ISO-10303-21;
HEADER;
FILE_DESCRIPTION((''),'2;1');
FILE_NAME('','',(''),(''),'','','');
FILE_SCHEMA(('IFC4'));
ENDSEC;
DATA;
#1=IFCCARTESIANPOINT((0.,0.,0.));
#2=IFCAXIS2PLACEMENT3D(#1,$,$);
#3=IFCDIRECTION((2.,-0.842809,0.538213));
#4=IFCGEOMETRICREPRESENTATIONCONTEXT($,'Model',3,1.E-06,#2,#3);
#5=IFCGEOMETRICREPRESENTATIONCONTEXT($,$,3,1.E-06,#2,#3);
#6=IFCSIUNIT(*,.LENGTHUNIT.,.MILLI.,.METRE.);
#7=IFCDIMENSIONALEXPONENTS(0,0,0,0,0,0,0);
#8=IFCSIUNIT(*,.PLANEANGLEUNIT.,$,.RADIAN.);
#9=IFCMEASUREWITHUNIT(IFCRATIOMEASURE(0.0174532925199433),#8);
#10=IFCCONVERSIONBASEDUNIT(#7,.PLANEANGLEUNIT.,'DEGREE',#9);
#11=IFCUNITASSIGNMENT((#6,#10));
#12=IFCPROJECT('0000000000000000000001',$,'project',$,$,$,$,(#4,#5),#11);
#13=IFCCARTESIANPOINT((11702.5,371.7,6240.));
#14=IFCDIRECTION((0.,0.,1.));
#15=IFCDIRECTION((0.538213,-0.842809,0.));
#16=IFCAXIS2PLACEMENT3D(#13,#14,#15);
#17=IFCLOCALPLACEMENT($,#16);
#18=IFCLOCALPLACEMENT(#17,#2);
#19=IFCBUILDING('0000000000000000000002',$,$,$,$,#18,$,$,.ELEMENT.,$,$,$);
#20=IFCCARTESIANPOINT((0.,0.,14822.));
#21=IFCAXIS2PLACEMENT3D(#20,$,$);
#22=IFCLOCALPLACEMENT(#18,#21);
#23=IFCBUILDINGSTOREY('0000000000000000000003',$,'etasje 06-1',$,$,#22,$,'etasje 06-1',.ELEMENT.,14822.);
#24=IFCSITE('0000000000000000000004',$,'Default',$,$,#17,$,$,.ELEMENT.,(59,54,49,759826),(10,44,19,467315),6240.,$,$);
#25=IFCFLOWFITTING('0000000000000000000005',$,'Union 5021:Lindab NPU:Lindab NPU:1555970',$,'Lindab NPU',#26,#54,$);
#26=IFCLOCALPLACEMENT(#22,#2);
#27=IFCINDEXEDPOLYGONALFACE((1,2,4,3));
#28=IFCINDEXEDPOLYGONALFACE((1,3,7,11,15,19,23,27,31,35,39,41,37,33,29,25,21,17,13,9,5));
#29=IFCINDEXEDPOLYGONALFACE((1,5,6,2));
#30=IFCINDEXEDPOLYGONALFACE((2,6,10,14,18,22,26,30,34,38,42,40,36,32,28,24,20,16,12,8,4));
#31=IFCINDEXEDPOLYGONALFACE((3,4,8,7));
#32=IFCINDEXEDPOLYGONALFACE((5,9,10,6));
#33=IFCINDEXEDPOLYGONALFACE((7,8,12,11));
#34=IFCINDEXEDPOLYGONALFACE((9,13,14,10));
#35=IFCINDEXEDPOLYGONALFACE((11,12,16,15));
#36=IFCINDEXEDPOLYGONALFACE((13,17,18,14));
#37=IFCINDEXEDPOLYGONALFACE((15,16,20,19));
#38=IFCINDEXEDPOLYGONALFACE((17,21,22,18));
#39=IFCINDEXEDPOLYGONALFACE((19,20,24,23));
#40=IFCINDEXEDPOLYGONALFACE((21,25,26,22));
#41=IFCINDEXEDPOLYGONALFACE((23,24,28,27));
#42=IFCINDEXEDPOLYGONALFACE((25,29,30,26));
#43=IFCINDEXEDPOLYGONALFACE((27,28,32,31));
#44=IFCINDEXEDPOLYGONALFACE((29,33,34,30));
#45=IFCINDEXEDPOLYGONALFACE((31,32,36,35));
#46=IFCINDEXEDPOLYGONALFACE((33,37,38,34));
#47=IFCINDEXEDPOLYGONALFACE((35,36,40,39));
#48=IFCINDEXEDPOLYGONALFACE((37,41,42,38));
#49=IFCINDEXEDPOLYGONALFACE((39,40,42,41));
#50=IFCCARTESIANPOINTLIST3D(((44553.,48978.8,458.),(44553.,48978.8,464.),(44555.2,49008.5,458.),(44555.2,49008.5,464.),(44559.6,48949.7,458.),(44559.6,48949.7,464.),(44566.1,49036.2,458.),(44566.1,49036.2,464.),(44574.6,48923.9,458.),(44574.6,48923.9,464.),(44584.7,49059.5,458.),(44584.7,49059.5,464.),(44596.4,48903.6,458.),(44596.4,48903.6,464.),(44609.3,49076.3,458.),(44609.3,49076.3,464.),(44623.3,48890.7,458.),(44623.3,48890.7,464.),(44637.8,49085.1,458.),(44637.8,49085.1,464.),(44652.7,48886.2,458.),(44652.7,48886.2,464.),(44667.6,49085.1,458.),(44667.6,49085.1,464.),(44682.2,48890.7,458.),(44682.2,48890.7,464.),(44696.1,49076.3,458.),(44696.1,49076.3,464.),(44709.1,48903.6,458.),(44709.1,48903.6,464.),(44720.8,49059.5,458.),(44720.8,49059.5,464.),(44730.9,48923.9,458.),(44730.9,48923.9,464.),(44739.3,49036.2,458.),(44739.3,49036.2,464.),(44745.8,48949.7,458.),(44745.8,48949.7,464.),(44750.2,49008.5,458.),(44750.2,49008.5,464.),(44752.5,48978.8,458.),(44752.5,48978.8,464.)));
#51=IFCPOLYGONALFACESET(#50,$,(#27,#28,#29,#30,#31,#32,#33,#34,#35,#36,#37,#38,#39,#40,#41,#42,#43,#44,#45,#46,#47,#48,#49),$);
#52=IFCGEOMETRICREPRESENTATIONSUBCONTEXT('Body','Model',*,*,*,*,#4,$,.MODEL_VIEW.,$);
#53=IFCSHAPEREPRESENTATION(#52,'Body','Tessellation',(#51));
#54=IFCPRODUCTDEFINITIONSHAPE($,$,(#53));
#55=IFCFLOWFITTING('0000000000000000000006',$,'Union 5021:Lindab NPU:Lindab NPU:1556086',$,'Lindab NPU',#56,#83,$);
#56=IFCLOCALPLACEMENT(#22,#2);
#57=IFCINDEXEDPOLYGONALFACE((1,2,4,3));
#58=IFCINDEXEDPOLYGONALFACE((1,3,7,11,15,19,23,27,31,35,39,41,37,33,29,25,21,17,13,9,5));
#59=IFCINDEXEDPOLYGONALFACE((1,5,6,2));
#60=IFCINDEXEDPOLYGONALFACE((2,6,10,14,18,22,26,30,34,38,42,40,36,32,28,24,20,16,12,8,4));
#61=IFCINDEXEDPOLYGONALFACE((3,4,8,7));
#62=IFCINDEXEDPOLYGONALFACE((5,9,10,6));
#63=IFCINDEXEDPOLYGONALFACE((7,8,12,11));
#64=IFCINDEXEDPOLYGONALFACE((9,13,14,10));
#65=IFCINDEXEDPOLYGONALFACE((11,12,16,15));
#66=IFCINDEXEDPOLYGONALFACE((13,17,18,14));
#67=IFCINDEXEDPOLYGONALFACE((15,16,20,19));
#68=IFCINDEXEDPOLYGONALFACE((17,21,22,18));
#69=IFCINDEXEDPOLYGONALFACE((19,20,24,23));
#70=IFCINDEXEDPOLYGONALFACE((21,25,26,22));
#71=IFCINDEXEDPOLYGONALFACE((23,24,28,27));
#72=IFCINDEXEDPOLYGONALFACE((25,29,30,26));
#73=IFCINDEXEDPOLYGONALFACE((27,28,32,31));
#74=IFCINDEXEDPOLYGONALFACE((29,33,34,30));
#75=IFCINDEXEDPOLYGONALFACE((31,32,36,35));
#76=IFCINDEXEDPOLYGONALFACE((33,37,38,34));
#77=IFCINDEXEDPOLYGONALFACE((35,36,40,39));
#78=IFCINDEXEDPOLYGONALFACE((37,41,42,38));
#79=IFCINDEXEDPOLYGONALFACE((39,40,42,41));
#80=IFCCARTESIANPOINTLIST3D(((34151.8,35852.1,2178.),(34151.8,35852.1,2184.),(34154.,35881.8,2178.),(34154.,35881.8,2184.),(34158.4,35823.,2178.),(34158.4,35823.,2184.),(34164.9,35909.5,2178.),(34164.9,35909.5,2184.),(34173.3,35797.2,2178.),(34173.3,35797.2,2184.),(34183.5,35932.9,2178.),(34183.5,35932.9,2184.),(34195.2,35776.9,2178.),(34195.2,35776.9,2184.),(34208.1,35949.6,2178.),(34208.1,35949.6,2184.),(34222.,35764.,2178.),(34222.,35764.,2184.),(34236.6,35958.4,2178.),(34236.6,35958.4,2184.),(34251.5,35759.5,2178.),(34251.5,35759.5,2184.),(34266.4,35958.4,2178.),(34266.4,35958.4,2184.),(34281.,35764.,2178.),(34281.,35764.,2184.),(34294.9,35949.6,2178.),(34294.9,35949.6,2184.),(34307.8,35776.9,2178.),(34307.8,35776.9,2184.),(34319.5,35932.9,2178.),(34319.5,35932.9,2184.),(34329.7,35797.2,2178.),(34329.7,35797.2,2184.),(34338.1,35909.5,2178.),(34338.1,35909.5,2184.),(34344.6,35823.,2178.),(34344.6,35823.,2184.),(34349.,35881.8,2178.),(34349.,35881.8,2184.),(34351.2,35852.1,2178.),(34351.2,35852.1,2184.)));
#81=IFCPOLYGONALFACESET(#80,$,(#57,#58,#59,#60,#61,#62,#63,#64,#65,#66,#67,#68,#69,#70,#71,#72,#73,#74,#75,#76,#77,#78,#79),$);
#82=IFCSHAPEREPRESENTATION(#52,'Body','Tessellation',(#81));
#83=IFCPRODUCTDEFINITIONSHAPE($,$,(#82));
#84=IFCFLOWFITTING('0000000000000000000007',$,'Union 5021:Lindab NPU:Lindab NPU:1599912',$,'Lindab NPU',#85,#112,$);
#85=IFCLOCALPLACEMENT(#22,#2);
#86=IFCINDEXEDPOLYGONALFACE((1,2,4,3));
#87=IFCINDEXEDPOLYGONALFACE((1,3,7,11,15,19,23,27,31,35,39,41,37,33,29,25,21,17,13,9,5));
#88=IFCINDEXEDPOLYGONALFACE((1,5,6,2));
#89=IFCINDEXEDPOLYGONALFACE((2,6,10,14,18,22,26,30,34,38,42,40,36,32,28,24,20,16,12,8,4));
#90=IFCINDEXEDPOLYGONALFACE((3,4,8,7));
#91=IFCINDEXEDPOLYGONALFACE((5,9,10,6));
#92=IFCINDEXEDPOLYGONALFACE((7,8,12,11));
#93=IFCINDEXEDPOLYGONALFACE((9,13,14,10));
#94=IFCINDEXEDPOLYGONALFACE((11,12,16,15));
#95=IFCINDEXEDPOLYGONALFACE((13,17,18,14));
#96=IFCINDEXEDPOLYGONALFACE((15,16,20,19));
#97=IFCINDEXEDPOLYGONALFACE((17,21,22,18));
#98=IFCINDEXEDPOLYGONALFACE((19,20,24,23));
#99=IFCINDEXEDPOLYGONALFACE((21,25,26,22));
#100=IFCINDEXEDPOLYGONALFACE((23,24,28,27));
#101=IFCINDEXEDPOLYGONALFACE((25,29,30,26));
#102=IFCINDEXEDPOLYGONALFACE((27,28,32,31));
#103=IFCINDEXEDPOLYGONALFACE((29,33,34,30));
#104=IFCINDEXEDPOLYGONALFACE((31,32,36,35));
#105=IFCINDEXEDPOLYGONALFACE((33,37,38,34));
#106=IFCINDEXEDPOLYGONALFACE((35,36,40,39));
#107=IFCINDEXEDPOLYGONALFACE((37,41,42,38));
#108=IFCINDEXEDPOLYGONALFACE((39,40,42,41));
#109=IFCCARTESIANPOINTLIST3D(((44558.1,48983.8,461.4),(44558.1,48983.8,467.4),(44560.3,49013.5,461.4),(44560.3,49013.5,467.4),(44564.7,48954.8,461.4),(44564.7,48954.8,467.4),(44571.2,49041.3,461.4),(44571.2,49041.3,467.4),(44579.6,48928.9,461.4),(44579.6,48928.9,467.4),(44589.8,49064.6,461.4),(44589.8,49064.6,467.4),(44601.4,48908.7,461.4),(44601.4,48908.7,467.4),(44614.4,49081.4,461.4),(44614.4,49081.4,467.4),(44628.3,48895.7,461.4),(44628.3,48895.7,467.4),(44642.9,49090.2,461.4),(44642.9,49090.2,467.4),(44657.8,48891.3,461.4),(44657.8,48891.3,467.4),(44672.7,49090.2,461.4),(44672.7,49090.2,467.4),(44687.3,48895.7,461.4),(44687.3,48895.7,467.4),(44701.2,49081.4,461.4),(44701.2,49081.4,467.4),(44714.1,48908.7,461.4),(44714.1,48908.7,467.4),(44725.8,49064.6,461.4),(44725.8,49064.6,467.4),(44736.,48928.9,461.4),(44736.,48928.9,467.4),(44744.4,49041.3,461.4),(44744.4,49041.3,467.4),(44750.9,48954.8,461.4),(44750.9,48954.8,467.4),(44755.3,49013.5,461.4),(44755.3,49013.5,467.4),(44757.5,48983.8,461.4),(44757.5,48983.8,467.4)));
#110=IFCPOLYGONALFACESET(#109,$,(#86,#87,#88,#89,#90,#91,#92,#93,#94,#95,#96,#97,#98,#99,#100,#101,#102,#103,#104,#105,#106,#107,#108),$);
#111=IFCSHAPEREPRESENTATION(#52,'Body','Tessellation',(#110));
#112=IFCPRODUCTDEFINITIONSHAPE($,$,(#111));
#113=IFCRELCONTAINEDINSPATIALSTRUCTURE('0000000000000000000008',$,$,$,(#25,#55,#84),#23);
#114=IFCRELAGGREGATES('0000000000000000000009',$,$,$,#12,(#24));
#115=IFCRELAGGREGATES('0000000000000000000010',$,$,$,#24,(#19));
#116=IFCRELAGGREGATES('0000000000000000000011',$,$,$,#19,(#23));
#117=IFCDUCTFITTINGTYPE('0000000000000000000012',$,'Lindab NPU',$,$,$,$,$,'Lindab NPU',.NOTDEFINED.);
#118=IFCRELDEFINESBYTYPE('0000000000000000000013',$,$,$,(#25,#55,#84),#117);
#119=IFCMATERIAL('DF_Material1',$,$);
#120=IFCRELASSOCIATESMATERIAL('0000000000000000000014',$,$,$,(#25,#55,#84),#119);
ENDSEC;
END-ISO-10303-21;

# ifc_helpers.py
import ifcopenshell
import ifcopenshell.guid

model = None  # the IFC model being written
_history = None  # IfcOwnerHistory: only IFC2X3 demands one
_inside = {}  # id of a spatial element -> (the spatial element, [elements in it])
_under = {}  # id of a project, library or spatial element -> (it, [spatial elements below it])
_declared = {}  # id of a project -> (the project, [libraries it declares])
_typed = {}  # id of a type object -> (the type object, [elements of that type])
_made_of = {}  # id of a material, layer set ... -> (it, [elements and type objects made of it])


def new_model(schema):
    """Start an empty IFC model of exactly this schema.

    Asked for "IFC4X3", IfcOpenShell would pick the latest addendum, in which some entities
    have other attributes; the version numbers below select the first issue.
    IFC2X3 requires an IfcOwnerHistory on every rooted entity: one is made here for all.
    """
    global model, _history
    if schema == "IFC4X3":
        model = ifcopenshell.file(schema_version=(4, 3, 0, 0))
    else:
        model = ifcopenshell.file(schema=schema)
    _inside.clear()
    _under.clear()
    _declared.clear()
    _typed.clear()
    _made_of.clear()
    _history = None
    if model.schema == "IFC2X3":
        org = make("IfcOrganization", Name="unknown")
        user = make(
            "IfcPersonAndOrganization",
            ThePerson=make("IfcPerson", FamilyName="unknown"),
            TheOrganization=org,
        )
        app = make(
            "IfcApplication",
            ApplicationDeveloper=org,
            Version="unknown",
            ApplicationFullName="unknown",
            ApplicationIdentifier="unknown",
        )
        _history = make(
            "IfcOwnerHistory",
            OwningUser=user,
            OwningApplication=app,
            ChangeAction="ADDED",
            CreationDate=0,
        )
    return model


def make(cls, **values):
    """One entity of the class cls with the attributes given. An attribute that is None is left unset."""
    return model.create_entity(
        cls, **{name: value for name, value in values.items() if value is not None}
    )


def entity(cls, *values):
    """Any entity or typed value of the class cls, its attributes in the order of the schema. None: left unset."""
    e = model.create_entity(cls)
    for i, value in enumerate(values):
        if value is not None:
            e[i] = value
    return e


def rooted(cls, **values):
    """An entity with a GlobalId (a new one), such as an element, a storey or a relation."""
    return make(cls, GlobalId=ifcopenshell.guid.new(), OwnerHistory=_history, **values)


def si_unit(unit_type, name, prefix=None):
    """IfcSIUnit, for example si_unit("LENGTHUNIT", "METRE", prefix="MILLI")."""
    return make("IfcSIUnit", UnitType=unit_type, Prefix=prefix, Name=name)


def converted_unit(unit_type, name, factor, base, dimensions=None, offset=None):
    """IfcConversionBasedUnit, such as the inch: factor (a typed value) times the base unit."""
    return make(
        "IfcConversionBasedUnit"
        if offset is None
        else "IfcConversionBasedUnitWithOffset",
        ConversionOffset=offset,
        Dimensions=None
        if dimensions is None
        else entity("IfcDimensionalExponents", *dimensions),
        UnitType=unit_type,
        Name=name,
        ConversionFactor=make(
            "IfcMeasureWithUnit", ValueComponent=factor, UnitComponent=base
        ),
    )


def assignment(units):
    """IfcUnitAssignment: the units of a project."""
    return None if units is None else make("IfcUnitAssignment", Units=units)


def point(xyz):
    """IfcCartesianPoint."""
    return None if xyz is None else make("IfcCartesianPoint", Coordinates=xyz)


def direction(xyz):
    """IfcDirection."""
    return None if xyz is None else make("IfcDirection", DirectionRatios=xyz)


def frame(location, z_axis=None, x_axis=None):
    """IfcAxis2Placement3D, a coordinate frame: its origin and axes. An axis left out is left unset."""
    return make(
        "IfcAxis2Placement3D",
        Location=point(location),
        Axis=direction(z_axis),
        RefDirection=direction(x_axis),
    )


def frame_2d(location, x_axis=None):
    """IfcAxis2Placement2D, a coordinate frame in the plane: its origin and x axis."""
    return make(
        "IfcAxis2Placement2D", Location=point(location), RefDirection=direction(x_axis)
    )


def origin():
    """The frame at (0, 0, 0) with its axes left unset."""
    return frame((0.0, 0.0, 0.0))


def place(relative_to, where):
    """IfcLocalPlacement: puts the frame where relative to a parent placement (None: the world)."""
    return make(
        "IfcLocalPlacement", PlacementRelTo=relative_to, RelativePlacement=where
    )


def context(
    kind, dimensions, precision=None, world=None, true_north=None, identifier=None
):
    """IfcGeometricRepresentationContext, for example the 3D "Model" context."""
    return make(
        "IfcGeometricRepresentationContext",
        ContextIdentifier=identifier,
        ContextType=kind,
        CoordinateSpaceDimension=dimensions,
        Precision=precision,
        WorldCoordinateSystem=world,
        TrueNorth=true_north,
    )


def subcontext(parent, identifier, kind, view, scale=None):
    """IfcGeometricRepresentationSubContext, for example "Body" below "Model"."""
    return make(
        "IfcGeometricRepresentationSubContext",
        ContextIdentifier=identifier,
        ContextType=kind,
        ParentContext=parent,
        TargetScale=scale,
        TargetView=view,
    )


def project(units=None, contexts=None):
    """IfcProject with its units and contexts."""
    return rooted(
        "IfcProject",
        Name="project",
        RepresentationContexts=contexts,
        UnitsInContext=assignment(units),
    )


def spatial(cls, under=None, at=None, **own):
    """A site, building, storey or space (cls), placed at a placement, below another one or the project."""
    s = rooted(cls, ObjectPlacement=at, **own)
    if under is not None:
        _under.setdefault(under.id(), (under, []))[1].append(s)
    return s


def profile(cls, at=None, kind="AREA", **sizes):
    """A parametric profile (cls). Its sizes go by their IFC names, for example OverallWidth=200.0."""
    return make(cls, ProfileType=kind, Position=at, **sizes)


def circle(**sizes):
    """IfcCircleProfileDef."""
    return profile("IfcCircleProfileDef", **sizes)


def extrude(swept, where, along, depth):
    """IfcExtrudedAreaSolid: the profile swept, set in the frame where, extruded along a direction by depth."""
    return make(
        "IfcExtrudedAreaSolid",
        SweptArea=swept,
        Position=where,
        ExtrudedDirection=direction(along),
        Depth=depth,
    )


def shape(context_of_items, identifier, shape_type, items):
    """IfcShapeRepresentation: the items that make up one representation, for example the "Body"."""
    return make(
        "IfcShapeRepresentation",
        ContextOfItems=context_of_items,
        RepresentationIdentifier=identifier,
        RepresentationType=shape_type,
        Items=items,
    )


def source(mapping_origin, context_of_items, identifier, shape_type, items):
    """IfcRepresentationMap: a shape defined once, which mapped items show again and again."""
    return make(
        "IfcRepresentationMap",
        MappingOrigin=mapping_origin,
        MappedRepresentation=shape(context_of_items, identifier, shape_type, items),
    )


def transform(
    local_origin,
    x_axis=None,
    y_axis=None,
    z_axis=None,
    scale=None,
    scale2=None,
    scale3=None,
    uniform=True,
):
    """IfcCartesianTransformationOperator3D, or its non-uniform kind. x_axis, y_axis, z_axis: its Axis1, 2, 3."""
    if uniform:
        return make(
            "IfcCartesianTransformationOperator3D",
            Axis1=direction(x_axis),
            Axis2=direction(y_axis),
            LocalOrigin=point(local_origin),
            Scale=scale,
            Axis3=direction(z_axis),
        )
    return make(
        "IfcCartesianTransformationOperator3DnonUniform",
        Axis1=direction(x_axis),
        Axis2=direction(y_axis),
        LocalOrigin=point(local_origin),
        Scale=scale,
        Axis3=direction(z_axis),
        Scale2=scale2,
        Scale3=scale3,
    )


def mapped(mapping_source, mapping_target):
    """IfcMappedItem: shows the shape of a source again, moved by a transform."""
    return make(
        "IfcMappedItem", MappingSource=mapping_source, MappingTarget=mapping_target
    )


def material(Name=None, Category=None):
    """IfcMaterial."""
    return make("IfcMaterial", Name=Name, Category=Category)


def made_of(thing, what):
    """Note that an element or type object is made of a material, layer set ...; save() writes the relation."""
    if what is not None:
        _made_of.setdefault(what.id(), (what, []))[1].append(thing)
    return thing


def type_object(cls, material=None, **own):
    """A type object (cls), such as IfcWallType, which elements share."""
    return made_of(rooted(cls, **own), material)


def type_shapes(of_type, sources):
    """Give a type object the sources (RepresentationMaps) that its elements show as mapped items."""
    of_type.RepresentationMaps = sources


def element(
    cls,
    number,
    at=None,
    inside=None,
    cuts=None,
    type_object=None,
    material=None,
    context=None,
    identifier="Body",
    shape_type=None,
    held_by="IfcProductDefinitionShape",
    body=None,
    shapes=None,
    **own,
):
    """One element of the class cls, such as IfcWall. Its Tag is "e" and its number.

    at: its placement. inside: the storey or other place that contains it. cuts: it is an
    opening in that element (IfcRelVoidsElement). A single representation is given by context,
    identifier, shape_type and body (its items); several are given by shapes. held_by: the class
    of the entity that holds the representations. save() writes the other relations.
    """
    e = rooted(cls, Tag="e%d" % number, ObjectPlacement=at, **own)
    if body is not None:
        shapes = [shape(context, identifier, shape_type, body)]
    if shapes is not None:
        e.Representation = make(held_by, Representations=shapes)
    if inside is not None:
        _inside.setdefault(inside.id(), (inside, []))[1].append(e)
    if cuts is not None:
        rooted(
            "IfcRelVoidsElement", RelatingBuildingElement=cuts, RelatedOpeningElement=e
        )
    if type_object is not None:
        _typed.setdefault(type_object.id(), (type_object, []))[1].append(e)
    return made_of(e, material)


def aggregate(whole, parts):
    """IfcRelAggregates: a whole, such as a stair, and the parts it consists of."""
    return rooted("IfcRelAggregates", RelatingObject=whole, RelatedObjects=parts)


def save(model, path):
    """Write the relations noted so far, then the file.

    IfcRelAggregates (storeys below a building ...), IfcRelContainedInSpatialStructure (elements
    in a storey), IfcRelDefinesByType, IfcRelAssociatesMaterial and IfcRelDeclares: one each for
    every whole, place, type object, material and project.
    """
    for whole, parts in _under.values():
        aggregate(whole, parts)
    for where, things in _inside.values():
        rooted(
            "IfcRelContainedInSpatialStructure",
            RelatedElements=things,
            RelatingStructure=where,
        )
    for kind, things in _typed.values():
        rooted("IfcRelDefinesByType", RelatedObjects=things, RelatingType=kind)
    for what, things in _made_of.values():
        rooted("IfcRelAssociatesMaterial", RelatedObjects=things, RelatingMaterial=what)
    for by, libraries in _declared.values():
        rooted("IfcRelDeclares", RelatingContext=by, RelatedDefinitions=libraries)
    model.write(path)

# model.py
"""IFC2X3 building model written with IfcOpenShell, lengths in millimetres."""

from ifc_helpers import new_model, entity, si_unit, converted_unit, direction, frame, frame_2d, origin, place, context, subcontext, project, spatial, circle, extrude, source, transform, mapped, material, type_object, type_shapes, element, save


model = new_model("IFC2X3")

# Units and contexts
model_context = context("Model", 3, precision=1e-06, world=origin(), true_north=direction((2.0, -0.842809, 0.538213)))
context_of_model = context(None, 3, precision=1e-06, world=origin(), true_north=direction((2.0, -0.842809, 0.538213)))
body_context = subcontext(model_context, "Body", "Model", "MODEL_VIEW")
ifc_project = project(units=[si_unit("LENGTHUNIT", "METRE", prefix="MILLI"), converted_unit("PLANEANGLEUNIT", "DEGREE", entity("IfcRatioMeasure", 0.0174532925199433), si_unit("PLANEANGLEUNIT", "RADIAN"), dimensions=[0, 0, 0, 0, 0, 0, 0])], contexts=[model_context, context_of_model])

# Site, building, storey
site_placement = place(None, frame((11702.5, 371.7, 6240.0), z_axis=(0.0, 0.0, 1.0), x_axis=(0.538213, -0.842809, 0.0)))
site = spatial("IfcSite", under=ifc_project, at=site_placement, Name="Default", CompositionType="ELEMENT", RefLatitude=(59, 54, 49, 759826), RefLongitude=(10, 44, 19, 467315), RefElevation=6240.0)
building_placement = place(site_placement, origin())
building = spatial("IfcBuilding", under=site, at=building_placement, CompositionType="ELEMENT")
storey_placement = place(building_placement, frame((0.0, 0.0, 14822.0)))
storey = spatial("IfcBuildingStorey", under=building, at=storey_placement, Name="etasje 06-1", LongName="etasje 06-1", CompositionType="ELEMENT", Elevation=14822.0)

# Flow fittings
ifc_material = material(Name="DF_Material1")
duct_fitting_type = type_object("IfcDuctFittingType", Name="Lindab NPU", ElementType="Lindab NPU", PredefinedType="NOTDEFINED")
shared_shape = source(origin(), body_context, "Body", "SweptSolid", [
    extrude(circle(Radius=100.0, at=frame_2d((0.0, 0.0), x_axis=(1.0, 0.0))), frame((0.0, 0.0, 0.0), z_axis=(1.0, 0.0, 0.0), x_axis=(0.0, 1.0, 0.0)), (0.0, 0.0, 1.0), 6.0),
])
type_shapes(duct_fitting_type, [shared_shape])
for number, where, z_axis, x_axis, name in (
    (1, (44652.7, 48986.2, 458.0), (1.0, 0.0, 0.0), (0.0, 0.0, 1.0), "Union 5021:Lindab NPU:Lindab NPU:1555970"),
    (2, (34251.5, 35859.5, 2178.0), (1.0, 0.0, 0.0), (0.0, 0.0, 1.0), "Union 5021:Lindab NPU:Lindab NPU:1556086"),
    (3, (44657.8, 48991.3, 461.4), (1.0, 0.0, 0.0), (0.0, 0.0, 1.0), "Union 5021:Lindab NPU:Lindab NPU:1599912"),
):
    element("IfcFlowFitting", number, at=place(storey_placement, frame(where, z_axis=z_axis, x_axis=x_axis)), inside=storey, type_object=duct_fitting_type, material=ifc_material, Name=name, ObjectType="Lindab NPU", context=body_context, shape_type="MappedRepresentation", body=[
        mapped(shared_shape, transform((0.0, 0.0, 0.0), scale=1.0)),
    ])

save(model, "model.ifc")
